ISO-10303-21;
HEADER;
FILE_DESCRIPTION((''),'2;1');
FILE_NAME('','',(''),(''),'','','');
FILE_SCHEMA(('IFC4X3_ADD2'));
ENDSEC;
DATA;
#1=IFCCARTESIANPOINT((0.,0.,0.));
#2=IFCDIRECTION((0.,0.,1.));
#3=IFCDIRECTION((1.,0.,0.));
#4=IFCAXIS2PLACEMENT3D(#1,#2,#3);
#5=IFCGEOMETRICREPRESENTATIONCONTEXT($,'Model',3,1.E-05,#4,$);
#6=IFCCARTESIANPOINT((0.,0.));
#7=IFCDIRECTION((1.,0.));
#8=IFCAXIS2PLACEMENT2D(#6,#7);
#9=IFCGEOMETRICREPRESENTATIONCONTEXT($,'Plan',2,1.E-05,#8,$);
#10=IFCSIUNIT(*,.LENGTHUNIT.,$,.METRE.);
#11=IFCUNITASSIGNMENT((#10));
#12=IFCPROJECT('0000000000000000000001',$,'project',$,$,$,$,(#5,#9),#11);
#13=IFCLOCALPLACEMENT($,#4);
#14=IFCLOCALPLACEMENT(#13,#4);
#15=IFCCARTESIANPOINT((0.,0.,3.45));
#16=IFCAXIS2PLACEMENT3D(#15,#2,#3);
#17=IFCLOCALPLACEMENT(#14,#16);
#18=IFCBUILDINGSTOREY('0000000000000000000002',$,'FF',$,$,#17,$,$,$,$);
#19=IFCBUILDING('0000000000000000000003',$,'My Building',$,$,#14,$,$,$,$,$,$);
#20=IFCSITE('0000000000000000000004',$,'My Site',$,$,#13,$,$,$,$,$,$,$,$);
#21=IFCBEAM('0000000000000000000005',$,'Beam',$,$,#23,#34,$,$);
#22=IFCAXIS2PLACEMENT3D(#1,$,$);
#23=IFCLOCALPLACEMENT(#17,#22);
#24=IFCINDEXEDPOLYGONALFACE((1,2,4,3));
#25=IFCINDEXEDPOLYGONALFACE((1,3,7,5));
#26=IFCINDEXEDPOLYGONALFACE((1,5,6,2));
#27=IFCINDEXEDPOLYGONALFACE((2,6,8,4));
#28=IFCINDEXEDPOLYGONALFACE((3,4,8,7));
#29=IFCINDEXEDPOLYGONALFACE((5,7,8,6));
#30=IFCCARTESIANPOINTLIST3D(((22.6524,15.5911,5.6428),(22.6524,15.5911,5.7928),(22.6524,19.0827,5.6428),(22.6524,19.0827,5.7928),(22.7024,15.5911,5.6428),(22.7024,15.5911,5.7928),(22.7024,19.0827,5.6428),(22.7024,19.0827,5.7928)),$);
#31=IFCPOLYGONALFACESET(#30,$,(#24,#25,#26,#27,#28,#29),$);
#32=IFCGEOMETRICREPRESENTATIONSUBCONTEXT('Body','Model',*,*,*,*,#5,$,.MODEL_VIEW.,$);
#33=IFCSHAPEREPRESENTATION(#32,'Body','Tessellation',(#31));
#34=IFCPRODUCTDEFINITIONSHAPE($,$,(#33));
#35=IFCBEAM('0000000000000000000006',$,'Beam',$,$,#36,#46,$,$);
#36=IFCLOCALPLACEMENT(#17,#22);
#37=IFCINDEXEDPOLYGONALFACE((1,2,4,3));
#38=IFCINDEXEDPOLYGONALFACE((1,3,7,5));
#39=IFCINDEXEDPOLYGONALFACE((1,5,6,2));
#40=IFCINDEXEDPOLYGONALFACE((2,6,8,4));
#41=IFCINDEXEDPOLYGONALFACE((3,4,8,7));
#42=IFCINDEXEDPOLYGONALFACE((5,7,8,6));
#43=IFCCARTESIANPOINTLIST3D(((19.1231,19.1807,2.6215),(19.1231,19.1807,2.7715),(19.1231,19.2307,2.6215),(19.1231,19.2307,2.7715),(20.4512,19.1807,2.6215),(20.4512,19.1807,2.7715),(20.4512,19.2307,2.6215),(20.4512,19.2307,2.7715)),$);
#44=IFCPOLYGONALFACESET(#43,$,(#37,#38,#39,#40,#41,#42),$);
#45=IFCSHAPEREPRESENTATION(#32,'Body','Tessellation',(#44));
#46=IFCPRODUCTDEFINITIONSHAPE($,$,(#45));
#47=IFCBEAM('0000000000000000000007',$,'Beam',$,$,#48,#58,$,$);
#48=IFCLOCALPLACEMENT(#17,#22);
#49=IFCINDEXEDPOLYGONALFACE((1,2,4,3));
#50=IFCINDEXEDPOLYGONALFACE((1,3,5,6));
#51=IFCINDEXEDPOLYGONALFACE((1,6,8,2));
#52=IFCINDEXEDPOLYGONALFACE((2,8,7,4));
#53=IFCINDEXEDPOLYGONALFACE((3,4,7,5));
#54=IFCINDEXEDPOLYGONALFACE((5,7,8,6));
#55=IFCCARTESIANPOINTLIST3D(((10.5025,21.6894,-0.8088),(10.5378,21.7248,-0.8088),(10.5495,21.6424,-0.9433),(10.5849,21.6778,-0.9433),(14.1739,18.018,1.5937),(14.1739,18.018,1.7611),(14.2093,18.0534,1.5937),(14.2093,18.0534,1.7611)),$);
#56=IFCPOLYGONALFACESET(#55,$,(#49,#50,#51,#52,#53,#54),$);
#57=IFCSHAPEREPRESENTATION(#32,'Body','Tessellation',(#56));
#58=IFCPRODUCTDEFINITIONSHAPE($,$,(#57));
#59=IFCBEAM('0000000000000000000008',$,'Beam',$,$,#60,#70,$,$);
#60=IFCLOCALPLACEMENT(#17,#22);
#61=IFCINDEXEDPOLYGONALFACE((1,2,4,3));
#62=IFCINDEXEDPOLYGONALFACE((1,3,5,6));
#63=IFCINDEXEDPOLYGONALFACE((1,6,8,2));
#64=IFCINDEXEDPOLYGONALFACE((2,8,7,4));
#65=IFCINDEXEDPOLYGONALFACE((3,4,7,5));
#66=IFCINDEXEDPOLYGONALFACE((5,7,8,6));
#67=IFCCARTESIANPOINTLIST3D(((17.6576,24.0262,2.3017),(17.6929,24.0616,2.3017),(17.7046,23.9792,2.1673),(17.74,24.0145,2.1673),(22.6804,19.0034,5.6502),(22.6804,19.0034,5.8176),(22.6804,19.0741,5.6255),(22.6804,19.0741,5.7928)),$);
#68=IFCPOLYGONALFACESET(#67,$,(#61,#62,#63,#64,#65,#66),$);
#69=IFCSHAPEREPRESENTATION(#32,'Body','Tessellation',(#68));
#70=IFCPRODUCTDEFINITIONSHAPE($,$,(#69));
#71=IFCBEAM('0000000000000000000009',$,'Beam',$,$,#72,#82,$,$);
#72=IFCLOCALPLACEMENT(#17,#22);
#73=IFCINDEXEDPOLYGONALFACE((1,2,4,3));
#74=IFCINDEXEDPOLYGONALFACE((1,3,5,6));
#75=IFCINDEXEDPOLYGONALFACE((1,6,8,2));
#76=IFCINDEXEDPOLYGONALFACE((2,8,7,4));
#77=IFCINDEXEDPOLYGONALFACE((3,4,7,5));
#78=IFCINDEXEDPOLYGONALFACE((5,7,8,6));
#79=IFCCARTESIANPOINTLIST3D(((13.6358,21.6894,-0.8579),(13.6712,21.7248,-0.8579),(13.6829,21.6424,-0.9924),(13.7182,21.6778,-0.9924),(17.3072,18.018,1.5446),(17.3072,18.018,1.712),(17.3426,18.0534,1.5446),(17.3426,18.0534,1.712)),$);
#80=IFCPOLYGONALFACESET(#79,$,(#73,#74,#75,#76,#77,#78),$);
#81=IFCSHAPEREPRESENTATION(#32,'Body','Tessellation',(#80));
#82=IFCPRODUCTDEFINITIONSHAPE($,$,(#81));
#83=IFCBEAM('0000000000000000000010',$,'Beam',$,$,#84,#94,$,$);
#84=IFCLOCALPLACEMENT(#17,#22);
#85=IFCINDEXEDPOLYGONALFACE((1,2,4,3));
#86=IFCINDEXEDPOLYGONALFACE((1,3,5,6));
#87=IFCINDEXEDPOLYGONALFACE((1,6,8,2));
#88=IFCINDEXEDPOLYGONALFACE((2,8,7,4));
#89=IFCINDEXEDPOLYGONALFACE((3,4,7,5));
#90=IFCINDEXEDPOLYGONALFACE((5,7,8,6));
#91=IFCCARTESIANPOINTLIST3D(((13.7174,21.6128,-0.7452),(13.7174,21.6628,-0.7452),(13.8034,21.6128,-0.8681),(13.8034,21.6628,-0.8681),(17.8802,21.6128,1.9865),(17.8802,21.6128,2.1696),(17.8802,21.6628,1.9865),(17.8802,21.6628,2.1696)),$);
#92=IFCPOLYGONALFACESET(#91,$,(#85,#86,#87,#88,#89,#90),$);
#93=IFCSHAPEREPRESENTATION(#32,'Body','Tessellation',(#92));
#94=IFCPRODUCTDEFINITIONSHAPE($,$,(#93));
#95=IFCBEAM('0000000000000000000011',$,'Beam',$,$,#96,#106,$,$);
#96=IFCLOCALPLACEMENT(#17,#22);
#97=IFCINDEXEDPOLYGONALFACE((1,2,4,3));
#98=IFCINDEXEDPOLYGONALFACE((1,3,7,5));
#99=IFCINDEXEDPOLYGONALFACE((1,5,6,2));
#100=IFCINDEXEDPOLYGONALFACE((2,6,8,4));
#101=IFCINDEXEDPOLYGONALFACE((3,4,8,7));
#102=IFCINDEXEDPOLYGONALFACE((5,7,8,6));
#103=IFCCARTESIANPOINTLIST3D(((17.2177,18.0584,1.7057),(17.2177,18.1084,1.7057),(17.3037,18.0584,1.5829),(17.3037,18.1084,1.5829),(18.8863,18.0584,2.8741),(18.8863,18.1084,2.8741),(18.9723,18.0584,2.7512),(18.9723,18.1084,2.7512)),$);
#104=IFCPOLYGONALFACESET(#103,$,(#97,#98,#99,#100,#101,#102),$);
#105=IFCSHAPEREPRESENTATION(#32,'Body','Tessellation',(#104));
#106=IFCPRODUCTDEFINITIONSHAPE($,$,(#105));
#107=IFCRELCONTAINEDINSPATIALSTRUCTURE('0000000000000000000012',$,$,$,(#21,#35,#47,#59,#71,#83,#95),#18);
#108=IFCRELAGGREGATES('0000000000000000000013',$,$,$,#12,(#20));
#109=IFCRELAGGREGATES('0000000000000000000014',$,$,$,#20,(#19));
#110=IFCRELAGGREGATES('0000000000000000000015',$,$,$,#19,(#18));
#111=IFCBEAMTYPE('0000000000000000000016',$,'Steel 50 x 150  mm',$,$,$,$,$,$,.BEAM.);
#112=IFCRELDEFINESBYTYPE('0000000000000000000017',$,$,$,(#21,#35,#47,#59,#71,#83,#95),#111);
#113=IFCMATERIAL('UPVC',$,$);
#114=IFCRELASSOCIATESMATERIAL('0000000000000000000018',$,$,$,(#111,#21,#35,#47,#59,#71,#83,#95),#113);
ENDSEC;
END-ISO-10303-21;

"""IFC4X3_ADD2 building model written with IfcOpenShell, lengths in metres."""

from ifc_helpers import new_model, si_unit, frame, origin_with_axes, origin_2d_with_axis, place, context, subcontext, project, spatial, rectangle, extrude, clip, halfspace, material, material_profile, profile_set, profile_usage, type_object, element, save


model = new_model("IFC4X3_ADD2")

# Units and contexts
model_context = context("Model", 3, precision=1e-05, world=origin_with_axes())
plan_context = context("Plan", 2, precision=1e-05, world=origin_2d_with_axis())
body_context_1 = subcontext(model_context, "Body", "Model", "MODEL_VIEW")
ifc_project = project(units=[si_unit("LENGTHUNIT", "METRE")], contexts=[model_context, plan_context])

# Site, building, storey
site_placement = place(None, origin_with_axes())
site = spatial("IfcSite", under=ifc_project, at=site_placement, Name="My Site")
building_placement = place(site_placement, origin_with_axes())
building = spatial("IfcBuilding", under=site, at=building_placement, Name="My Building")
storey_placement = place(building_placement, frame((0.0, 0.0, 3.45), z_axis=(0.0, 0.0, 1.0), x_axis=(1.0, 0.0, 0.0)))
storey = spatial("IfcBuildingStorey", under=building, at=storey_placement, Name="FF")

# Beams
ifc_material_1 = material(Name="UPVC")
ifc_material_profile = material_profile(ifc_material_1, rectangle(XDim=0.05, YDim=0.15))
ifc_profile_set = profile_set([ifc_material_profile])
ifc_profile_usage_1 = profile_usage(ifc_profile_set)
beam_type = type_object("IfcBeamType", Name="Steel 50 x 150  mm", PredefinedType="BEAM", material=ifc_profile_set)
beam_1_placement = place(storey_placement, frame((22.6774, 19.0827, 5.7178), z_axis=(0.0, -1.0, 0.0), x_axis=(1.0, 0.0, 0.0)))
element("IfcBeam", 1, at=beam_1_placement, inside=storey, type_object=beam_type, material=ifc_profile_usage_1, Name="Beam", context=body_context_1, shape_type="SweptSolid", body=[
    extrude(rectangle(XDim=0.05, YDim=0.15), origin_with_axes(), (0.0, 0.0, 1.0), 3.4917),
])
ifc_profile_usage_2 = profile_usage(ifc_profile_set)
beam_2_placement = place(storey_placement, frame((19.1231, 19.2057, 2.6965), z_axis=(1.0, 0.0, 0.0), x_axis=(0.0, 1.0, 0.0)))
element("IfcBeam", 2, at=beam_2_placement, inside=storey, type_object=beam_type, material=ifc_profile_usage_2, Name="Beam", context=body_context_1, shape_type="SweptSolid", body=[
    extrude(rectangle(XDim=0.05, YDim=0.15), origin_with_axes(), (0.0, 0.0, 1.0), 1.3281),
])
ifc_profile_usage_3 = profile_usage(ifc_profile_set)
beam_3_placement = place(storey_placement, frame((10.5437, 21.6836, -0.8761), z_axis=(0.633729, -0.63373, 0.443593), x_axis=(0.707107, 0.707106, 0.0)))
element("IfcBeam", 3, at=beam_3_placement, inside=storey, type_object=beam_type, material=ifc_profile_usage_3, Name="Beam", context=body_context_1, shape_type="Clipping", body=[
    clip(extrude(rectangle(XDim=0.05, YDim=0.15), origin_with_axes(), (0.0, 0.0, 1.0), 5.9063), halfspace(frame((-5.1467, -2.2885, 4.6236), z_axis=(0.0, -0.443593, 0.896229), x_axis=(-1.0, 0.0, 0.0)), False)),
])
ifc_profile_usage_4 = profile_usage(ifc_profile_set)
beam_4_placement = place(storey_placement, frame((17.6988, 24.0204, 2.2345), z_axis=(0.633729, -0.633729, 0.443593), x_axis=(0.707107, 0.707107, 0.0)))
element("IfcBeam", 4, at=beam_4_placement, inside=storey, type_object=beam_type, material=ifc_profile_usage_4, Name="Beam", context=body_context_1, shape_type="Clipping", body=[
    clip(extrude(rectangle(XDim=0.05, YDim=0.15), origin_with_axes(), (0.0, 0.0, 1.0), 8.0387), halfspace(frame((-0.025, -8.2743, 3.7933), z_axis=(0.707107, -0.313667, 0.633729), x_axis=(-0.405488, -0.9141, 0.0)), False)),
])
ifc_profile_usage_5 = profile_usage(ifc_profile_set)
beam_5_placement = place(storey_placement, frame((13.677, 21.6836, -0.9252), z_axis=(0.633729, -0.63373, 0.443593), x_axis=(0.707107, 0.707106, 0.0)))
element("IfcBeam", 5, at=beam_5_placement, inside=storey, type_object=beam_type, material=ifc_profile_usage_5, Name="Beam", context=body_context_1, shape_type="Clipping", body=[
    clip(extrude(rectangle(XDim=0.05, YDim=0.15), origin_with_axes(), (0.0, 0.0, 1.0), 5.9063), halfspace(frame((-5.1467, -2.2885, 4.6236), z_axis=(0.0, -0.443593, 0.896229), x_axis=(-1.0, 0.0, 0.0)), False)),
])
ifc_profile_usage_6 = profile_usage(ifc_profile_set)
beam_6_placement = place(storey_placement, frame((13.7604, 21.6378, -0.8066), z_axis=(0.819152, 0.0, 0.573576), x_axis=(0.000001, 1.0, 0.0)))
element("IfcBeam", 6, at=beam_6_placement, inside=storey, type_object=beam_type, material=ifc_profile_usage_6, Name="Beam", context=body_context_1, shape_type="Clipping", body=[
    clip(extrude(rectangle(XDim=0.05, YDim=0.15), origin_with_axes(), (0.0, 0.0, 1.0), 5.1793), halfspace(frame((-10.9369, 0.1639, 5.1441), z_axis=(0.0, -0.573577, 0.819152), x_axis=(-1.0, -0.000001, 0.0)), False)),
])
ifc_profile_usage_7 = profile_usage(ifc_profile_set)
beam_7_placement = place(storey_placement, frame((17.2607, 18.0834, 1.6443), z_axis=(0.819152, 0.0, 0.573576), x_axis=(0.000001, 1.0, 0.0)))
element("IfcBeam", 7, at=beam_7_placement, inside=storey, type_object=beam_type, material=ifc_profile_usage_7, Name="Beam", context=body_context_1, shape_type="SweptSolid", body=[
    extrude(rectangle(XDim=0.05, YDim=0.15), origin_with_axes(), (0.0, 0.0, 1.0), 2.0369),
])

save(model, "model.ifc")
